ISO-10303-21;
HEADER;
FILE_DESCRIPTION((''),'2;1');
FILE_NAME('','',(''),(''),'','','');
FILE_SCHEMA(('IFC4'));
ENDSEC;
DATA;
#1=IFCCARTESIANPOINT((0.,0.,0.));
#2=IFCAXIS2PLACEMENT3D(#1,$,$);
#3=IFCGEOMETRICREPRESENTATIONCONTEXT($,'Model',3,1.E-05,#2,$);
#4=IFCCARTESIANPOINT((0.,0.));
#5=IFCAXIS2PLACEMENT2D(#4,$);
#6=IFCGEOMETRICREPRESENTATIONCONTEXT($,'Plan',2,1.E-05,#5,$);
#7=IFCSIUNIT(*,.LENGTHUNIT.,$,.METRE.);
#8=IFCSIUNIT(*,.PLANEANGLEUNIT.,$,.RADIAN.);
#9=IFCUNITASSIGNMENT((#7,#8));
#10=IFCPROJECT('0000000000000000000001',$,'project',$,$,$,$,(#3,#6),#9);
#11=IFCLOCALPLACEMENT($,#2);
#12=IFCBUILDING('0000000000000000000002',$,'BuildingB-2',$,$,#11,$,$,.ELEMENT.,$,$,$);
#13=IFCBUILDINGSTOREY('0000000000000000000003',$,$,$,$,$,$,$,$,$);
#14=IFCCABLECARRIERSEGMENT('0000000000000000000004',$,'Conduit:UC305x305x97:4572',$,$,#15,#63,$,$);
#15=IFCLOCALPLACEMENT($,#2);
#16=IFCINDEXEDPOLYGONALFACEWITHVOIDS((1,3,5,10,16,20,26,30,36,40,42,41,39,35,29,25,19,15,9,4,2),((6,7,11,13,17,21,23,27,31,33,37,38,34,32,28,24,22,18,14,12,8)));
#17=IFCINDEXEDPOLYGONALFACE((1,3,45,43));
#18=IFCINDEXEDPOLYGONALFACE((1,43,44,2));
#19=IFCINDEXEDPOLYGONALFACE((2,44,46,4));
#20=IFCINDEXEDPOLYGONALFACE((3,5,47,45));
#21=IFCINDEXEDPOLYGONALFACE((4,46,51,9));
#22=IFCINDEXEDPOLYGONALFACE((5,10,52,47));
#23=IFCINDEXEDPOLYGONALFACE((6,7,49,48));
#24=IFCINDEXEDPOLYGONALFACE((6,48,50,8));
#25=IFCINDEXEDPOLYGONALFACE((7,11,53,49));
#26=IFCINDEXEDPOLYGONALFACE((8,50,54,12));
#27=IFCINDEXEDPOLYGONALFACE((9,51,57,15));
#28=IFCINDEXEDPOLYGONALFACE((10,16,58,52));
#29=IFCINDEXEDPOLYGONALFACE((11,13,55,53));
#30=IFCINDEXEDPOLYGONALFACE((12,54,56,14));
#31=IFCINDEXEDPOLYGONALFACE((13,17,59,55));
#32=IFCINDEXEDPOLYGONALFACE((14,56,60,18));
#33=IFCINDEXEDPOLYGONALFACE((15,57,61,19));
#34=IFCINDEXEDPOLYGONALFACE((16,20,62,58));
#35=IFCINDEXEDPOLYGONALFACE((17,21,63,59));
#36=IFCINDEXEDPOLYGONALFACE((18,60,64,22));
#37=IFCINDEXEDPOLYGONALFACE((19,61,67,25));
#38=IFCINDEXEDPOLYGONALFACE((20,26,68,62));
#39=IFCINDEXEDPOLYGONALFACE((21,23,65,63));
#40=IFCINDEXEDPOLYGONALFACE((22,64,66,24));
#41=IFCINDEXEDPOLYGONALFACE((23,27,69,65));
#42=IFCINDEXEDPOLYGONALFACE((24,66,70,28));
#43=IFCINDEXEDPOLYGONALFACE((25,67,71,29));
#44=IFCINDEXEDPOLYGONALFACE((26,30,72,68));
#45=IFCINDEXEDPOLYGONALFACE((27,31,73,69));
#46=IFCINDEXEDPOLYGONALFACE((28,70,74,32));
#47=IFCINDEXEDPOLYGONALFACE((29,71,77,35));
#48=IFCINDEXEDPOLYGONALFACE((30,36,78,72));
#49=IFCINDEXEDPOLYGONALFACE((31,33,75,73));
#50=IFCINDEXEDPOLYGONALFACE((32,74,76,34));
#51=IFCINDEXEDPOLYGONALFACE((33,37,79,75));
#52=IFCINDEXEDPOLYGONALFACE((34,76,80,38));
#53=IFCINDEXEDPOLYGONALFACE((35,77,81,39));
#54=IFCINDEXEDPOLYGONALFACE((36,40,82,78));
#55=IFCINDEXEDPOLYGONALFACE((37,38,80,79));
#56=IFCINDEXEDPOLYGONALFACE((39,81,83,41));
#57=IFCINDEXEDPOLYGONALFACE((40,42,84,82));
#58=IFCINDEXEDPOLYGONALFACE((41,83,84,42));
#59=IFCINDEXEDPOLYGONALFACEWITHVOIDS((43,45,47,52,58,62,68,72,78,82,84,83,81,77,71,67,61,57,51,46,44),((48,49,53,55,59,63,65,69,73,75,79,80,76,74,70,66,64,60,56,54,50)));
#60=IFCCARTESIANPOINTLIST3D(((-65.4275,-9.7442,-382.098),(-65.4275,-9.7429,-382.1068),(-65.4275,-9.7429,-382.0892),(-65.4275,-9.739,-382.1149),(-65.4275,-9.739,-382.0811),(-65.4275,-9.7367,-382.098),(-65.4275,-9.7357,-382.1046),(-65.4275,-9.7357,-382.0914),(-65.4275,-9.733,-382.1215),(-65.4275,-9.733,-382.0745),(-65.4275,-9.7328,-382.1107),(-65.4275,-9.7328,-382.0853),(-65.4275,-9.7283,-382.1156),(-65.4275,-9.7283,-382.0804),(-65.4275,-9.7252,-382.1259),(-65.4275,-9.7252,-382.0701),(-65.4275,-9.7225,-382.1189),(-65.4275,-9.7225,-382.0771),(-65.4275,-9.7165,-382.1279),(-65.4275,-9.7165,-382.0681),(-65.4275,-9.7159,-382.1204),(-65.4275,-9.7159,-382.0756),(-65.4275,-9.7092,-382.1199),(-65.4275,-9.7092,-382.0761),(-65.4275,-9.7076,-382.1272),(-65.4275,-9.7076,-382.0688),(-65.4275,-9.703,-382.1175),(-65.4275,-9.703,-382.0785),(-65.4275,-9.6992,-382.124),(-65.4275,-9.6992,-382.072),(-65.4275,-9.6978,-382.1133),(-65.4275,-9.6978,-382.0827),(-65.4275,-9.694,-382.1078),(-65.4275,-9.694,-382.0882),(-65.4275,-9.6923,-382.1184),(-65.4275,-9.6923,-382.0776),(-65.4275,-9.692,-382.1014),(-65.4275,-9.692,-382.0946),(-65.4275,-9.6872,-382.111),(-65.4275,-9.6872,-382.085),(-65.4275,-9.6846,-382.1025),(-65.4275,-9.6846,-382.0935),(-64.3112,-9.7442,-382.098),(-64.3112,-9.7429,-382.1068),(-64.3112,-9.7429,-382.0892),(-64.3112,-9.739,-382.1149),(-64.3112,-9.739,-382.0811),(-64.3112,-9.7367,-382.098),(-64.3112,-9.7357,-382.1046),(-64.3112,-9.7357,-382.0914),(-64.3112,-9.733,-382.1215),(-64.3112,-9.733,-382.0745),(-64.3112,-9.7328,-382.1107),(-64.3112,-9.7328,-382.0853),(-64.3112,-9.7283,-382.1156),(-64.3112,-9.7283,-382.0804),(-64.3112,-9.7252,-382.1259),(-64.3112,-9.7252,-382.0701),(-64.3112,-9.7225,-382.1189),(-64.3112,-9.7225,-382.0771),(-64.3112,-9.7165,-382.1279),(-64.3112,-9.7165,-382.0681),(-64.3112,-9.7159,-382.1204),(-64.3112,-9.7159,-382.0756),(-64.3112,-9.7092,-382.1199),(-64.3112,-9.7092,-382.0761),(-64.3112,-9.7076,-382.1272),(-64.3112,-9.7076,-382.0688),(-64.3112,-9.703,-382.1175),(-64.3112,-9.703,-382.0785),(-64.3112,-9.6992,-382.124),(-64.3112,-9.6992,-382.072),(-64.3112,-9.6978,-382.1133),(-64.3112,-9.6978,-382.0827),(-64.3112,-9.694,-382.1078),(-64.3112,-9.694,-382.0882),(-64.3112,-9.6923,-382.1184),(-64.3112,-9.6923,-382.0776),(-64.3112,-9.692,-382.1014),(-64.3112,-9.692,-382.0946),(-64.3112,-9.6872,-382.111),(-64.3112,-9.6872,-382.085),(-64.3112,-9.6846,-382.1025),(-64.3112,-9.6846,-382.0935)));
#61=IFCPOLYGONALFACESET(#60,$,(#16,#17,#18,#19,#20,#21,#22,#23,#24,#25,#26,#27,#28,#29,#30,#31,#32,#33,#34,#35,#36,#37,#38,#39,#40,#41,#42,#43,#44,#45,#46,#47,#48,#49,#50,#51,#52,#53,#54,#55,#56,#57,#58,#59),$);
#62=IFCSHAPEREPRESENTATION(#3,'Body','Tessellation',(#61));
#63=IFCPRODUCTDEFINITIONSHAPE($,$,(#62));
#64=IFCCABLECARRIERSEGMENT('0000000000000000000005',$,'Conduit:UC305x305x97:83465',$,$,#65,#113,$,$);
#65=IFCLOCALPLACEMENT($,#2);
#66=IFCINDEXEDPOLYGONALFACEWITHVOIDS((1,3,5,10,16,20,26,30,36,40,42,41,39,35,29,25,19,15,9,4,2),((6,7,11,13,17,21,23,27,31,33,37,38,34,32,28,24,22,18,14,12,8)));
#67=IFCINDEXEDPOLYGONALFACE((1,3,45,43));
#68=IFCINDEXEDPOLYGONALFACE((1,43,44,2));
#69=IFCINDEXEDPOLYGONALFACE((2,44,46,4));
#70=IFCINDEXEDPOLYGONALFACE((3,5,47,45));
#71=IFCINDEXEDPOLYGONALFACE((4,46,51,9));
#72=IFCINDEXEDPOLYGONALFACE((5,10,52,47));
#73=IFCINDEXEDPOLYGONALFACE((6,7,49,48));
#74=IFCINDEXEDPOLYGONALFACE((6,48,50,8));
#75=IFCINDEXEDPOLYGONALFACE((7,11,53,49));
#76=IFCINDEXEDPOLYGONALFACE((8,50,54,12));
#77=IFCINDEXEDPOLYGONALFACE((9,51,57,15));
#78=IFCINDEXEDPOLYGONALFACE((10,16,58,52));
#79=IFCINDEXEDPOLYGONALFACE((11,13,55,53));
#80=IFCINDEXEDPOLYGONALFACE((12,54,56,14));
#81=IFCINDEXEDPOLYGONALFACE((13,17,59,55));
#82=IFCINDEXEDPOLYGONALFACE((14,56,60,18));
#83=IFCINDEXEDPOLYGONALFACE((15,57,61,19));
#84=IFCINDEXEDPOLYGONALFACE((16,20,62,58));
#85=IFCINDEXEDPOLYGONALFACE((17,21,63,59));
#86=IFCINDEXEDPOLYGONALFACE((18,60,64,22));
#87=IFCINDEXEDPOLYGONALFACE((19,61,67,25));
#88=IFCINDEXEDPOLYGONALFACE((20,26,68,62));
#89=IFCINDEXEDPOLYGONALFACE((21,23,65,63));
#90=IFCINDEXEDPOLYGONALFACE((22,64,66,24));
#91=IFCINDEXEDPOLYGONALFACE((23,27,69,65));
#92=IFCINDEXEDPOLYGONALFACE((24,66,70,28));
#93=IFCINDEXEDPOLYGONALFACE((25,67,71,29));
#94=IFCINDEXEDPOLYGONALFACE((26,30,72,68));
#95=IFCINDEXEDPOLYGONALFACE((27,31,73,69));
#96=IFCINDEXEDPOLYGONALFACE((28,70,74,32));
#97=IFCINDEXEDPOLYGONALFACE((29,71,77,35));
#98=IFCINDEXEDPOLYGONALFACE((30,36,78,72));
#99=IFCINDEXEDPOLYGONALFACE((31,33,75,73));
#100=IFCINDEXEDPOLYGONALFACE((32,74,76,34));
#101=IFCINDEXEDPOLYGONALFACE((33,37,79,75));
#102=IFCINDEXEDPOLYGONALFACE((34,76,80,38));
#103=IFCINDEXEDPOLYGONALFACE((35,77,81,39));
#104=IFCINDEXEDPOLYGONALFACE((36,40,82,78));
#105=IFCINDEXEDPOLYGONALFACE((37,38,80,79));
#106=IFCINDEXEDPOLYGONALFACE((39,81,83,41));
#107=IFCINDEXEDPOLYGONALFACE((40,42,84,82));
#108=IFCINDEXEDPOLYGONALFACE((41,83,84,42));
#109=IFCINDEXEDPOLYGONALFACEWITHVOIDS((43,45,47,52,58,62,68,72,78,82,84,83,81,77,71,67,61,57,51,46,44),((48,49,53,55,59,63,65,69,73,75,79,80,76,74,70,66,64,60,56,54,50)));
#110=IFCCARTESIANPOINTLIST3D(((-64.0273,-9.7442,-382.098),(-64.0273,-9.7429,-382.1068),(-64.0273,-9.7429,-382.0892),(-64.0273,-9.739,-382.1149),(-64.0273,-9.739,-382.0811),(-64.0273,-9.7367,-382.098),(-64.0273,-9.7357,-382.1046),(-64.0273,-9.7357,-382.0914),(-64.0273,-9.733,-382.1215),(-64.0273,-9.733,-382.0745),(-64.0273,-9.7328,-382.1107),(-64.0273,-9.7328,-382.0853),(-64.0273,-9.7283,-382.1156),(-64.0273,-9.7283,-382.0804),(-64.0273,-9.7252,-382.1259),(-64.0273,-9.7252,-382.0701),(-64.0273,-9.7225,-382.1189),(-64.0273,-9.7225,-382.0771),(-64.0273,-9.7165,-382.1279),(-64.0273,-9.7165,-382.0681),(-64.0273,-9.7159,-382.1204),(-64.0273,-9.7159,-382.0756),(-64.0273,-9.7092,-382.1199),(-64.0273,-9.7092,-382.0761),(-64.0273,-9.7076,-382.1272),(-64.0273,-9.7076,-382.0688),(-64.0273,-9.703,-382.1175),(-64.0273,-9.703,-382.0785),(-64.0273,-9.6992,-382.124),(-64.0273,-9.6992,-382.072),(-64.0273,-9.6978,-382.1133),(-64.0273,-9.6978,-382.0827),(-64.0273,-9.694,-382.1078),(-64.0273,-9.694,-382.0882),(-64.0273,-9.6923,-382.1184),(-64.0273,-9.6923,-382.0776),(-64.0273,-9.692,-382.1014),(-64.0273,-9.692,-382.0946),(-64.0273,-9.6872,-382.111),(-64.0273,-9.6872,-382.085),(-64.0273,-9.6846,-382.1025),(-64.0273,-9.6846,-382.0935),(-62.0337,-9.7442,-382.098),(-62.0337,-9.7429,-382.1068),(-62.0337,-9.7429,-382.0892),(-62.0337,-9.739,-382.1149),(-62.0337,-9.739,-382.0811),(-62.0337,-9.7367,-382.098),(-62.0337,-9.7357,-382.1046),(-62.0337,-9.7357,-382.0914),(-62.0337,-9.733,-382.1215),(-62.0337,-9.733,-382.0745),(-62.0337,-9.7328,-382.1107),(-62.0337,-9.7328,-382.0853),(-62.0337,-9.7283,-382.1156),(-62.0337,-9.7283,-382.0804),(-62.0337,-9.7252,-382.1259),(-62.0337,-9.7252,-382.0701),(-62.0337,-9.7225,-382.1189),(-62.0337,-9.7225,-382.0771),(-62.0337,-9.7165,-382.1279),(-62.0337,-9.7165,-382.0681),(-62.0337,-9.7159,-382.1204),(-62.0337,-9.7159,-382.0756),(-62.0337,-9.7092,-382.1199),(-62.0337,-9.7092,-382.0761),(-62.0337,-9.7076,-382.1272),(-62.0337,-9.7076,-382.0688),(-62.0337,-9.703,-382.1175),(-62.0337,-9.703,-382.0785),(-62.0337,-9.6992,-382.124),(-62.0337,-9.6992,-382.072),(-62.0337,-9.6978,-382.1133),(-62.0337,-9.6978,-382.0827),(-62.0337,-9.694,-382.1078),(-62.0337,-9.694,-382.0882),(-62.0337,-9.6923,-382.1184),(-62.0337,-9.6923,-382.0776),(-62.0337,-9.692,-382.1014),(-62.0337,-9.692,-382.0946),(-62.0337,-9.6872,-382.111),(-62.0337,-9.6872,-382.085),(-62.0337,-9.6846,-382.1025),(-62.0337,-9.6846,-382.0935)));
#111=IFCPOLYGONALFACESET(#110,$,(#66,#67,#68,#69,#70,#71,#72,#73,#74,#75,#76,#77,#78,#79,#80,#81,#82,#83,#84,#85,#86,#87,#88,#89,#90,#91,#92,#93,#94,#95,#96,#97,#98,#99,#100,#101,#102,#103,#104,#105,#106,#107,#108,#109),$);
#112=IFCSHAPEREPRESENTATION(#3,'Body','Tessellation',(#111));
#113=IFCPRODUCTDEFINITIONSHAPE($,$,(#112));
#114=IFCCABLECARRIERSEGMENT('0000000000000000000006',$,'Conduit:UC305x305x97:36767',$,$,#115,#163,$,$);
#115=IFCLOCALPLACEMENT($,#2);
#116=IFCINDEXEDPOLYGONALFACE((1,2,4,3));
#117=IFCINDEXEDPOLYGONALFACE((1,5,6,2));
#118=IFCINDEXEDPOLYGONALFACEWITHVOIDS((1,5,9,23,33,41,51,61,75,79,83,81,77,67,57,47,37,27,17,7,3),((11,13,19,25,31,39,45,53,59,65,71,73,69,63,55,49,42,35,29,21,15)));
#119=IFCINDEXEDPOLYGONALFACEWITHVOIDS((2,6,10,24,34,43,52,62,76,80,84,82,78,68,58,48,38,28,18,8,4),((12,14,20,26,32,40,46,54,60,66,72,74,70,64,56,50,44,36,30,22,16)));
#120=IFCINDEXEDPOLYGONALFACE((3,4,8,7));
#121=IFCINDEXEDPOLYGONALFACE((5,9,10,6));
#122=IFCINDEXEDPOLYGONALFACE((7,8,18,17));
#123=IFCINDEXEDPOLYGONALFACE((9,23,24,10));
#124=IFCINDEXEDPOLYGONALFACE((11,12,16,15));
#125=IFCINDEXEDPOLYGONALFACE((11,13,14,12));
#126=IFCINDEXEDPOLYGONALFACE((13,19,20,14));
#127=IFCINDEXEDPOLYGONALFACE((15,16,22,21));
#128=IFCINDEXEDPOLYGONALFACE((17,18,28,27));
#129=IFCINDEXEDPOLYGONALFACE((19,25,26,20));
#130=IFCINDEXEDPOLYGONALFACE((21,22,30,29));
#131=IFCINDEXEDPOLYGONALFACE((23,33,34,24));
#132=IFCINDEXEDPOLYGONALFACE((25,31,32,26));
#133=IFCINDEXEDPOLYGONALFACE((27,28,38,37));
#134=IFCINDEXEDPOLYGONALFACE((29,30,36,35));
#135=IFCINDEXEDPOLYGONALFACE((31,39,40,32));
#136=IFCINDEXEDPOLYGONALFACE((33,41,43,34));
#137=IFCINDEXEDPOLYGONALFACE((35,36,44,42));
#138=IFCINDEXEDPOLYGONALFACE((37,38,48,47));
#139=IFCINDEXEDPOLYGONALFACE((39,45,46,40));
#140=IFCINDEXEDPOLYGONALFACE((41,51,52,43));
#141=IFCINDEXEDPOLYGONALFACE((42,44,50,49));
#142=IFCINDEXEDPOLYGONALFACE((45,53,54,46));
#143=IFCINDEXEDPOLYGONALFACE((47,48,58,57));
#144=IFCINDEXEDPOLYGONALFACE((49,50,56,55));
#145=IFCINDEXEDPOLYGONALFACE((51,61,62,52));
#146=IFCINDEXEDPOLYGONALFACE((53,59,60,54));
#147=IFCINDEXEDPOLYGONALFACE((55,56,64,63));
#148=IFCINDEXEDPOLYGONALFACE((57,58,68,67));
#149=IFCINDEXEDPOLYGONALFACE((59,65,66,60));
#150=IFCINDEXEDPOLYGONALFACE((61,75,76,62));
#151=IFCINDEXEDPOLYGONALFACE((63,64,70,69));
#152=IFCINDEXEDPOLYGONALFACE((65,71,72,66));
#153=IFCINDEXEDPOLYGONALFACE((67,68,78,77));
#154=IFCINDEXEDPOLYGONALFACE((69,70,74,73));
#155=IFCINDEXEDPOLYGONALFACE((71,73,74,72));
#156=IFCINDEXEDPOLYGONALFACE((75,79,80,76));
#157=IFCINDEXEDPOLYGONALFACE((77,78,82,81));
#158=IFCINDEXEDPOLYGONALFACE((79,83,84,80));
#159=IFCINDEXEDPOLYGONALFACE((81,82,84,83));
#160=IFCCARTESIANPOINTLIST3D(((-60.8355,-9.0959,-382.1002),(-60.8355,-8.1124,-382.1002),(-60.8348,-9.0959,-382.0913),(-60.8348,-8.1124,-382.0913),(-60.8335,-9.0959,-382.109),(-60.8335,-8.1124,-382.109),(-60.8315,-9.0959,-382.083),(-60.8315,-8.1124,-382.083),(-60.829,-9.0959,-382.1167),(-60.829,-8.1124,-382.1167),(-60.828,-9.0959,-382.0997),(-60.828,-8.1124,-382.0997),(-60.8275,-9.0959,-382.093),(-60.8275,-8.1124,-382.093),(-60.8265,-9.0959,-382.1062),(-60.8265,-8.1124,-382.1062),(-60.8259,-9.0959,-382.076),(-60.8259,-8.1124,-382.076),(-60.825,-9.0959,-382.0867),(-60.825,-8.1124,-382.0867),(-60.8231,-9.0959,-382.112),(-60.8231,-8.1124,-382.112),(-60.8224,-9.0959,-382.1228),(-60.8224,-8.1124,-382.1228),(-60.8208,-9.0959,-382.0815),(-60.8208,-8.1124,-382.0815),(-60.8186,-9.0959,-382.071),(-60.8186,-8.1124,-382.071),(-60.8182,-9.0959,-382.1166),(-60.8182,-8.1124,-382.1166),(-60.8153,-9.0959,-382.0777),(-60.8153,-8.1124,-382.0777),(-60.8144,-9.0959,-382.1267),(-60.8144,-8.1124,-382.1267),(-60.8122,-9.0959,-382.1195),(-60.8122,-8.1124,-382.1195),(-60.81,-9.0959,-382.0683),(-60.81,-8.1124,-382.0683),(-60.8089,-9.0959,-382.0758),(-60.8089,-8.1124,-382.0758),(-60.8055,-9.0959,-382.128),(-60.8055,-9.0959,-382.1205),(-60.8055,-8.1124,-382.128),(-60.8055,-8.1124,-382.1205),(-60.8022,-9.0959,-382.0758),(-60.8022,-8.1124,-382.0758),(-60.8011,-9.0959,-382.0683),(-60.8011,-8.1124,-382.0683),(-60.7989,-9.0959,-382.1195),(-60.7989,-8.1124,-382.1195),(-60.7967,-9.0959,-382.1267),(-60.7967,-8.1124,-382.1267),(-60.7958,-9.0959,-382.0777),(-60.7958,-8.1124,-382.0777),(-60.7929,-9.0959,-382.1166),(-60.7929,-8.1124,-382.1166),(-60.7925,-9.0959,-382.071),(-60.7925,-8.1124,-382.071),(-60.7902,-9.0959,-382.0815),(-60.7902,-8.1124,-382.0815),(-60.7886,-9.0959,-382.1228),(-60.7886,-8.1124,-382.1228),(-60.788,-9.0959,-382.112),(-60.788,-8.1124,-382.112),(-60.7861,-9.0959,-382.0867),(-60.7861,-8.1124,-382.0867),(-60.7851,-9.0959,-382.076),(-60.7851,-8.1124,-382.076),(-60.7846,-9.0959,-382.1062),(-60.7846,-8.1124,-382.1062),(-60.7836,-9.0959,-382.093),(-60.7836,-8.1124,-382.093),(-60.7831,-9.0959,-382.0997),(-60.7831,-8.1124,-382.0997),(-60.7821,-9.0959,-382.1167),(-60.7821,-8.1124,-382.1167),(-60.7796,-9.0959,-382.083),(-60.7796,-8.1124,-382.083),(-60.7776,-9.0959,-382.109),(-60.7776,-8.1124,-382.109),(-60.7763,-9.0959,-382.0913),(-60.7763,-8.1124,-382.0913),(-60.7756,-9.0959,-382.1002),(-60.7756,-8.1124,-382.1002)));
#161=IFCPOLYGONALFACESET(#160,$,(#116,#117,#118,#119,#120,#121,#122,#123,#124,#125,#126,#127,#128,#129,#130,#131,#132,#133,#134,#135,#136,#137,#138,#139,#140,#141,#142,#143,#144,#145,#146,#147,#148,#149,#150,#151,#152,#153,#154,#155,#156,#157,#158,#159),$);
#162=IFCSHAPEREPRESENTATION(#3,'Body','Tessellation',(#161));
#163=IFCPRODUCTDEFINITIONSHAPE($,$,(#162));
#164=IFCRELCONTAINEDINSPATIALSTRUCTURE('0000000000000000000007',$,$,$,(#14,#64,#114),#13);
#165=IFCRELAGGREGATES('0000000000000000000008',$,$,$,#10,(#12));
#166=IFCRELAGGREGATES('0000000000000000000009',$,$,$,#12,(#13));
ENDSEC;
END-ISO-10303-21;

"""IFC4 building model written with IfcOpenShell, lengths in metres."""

from ifc_helpers import new_model, entity, si_unit, origin, origin_2d, place, context, project, spatial, element, save


model = new_model("IFC4")

# Units and contexts
model_context = context("Model", 3, precision=1e-05, world=origin())
plan_context = context("Plan", 2, precision=1e-05, world=origin_2d())
ifc_project = project(units=[si_unit("LENGTHUNIT", "METRE"), si_unit("PLANEANGLEUNIT", "RADIAN")], contexts=[model_context, plan_context])

# Building, storey
building_placement = place(None, origin())
building = spatial("IfcBuilding", under=ifc_project, at=building_placement, Name="BuildingB-2", CompositionType="ELEMENT")
storey = spatial("IfcBuildingStorey", under=building)

# Cable carrier segments
element("IfcCableCarrierSegment", 1, inside=storey, Name="Conduit:UC305x305x97:4572", context=model_context, shape_type="AdvancedSweptSolid", body=[
    entity("IfcSweptDiskSolid", entity("IfcCompositeCurve", [entity("IfcCompositeCurveSegment", "CONTINUOUS", False, entity("IfcPolyline", [entity("IfcCartesianPoint", [65.4275, 9.7142, 382.098]), entity("IfcCartesianPoint", [64.3112, 9.7142, 382.098])]))], False), 0.03, 0.0225),
])
element("IfcCableCarrierSegment", 2, inside=storey, Name="Conduit:UC305x305x97:83465", context=model_context, shape_type="AdvancedSweptSolid", body=[
    entity("IfcSweptDiskSolid", entity("IfcCompositeCurve", [entity("IfcCompositeCurveSegment", "CONTINUOUS", False, entity("IfcPolyline", [entity("IfcCartesianPoint", [64.0273, 9.7142, 382.098]), entity("IfcCartesianPoint", [62.0337, 9.7142, 382.098])]))], False), 0.03, 0.0225),
])
element("IfcCableCarrierSegment", 3, inside=storey, Name="Conduit:UC305x305x97:36767", context=model_context, shape_type="AdvancedSweptSolid", body=[
    entity("IfcSweptDiskSolid", entity("IfcCompositeCurve", [entity("IfcCompositeCurveSegment", "CONTINUOUS", False, entity("IfcPolyline", [entity("IfcCartesianPoint", [60.8055, 9.0959, 382.098]), entity("IfcCartesianPoint", [60.8055, 8.1124, 382.098])]))], False), 0.03, 0.0225),
])

save(model, "model.ifc")
